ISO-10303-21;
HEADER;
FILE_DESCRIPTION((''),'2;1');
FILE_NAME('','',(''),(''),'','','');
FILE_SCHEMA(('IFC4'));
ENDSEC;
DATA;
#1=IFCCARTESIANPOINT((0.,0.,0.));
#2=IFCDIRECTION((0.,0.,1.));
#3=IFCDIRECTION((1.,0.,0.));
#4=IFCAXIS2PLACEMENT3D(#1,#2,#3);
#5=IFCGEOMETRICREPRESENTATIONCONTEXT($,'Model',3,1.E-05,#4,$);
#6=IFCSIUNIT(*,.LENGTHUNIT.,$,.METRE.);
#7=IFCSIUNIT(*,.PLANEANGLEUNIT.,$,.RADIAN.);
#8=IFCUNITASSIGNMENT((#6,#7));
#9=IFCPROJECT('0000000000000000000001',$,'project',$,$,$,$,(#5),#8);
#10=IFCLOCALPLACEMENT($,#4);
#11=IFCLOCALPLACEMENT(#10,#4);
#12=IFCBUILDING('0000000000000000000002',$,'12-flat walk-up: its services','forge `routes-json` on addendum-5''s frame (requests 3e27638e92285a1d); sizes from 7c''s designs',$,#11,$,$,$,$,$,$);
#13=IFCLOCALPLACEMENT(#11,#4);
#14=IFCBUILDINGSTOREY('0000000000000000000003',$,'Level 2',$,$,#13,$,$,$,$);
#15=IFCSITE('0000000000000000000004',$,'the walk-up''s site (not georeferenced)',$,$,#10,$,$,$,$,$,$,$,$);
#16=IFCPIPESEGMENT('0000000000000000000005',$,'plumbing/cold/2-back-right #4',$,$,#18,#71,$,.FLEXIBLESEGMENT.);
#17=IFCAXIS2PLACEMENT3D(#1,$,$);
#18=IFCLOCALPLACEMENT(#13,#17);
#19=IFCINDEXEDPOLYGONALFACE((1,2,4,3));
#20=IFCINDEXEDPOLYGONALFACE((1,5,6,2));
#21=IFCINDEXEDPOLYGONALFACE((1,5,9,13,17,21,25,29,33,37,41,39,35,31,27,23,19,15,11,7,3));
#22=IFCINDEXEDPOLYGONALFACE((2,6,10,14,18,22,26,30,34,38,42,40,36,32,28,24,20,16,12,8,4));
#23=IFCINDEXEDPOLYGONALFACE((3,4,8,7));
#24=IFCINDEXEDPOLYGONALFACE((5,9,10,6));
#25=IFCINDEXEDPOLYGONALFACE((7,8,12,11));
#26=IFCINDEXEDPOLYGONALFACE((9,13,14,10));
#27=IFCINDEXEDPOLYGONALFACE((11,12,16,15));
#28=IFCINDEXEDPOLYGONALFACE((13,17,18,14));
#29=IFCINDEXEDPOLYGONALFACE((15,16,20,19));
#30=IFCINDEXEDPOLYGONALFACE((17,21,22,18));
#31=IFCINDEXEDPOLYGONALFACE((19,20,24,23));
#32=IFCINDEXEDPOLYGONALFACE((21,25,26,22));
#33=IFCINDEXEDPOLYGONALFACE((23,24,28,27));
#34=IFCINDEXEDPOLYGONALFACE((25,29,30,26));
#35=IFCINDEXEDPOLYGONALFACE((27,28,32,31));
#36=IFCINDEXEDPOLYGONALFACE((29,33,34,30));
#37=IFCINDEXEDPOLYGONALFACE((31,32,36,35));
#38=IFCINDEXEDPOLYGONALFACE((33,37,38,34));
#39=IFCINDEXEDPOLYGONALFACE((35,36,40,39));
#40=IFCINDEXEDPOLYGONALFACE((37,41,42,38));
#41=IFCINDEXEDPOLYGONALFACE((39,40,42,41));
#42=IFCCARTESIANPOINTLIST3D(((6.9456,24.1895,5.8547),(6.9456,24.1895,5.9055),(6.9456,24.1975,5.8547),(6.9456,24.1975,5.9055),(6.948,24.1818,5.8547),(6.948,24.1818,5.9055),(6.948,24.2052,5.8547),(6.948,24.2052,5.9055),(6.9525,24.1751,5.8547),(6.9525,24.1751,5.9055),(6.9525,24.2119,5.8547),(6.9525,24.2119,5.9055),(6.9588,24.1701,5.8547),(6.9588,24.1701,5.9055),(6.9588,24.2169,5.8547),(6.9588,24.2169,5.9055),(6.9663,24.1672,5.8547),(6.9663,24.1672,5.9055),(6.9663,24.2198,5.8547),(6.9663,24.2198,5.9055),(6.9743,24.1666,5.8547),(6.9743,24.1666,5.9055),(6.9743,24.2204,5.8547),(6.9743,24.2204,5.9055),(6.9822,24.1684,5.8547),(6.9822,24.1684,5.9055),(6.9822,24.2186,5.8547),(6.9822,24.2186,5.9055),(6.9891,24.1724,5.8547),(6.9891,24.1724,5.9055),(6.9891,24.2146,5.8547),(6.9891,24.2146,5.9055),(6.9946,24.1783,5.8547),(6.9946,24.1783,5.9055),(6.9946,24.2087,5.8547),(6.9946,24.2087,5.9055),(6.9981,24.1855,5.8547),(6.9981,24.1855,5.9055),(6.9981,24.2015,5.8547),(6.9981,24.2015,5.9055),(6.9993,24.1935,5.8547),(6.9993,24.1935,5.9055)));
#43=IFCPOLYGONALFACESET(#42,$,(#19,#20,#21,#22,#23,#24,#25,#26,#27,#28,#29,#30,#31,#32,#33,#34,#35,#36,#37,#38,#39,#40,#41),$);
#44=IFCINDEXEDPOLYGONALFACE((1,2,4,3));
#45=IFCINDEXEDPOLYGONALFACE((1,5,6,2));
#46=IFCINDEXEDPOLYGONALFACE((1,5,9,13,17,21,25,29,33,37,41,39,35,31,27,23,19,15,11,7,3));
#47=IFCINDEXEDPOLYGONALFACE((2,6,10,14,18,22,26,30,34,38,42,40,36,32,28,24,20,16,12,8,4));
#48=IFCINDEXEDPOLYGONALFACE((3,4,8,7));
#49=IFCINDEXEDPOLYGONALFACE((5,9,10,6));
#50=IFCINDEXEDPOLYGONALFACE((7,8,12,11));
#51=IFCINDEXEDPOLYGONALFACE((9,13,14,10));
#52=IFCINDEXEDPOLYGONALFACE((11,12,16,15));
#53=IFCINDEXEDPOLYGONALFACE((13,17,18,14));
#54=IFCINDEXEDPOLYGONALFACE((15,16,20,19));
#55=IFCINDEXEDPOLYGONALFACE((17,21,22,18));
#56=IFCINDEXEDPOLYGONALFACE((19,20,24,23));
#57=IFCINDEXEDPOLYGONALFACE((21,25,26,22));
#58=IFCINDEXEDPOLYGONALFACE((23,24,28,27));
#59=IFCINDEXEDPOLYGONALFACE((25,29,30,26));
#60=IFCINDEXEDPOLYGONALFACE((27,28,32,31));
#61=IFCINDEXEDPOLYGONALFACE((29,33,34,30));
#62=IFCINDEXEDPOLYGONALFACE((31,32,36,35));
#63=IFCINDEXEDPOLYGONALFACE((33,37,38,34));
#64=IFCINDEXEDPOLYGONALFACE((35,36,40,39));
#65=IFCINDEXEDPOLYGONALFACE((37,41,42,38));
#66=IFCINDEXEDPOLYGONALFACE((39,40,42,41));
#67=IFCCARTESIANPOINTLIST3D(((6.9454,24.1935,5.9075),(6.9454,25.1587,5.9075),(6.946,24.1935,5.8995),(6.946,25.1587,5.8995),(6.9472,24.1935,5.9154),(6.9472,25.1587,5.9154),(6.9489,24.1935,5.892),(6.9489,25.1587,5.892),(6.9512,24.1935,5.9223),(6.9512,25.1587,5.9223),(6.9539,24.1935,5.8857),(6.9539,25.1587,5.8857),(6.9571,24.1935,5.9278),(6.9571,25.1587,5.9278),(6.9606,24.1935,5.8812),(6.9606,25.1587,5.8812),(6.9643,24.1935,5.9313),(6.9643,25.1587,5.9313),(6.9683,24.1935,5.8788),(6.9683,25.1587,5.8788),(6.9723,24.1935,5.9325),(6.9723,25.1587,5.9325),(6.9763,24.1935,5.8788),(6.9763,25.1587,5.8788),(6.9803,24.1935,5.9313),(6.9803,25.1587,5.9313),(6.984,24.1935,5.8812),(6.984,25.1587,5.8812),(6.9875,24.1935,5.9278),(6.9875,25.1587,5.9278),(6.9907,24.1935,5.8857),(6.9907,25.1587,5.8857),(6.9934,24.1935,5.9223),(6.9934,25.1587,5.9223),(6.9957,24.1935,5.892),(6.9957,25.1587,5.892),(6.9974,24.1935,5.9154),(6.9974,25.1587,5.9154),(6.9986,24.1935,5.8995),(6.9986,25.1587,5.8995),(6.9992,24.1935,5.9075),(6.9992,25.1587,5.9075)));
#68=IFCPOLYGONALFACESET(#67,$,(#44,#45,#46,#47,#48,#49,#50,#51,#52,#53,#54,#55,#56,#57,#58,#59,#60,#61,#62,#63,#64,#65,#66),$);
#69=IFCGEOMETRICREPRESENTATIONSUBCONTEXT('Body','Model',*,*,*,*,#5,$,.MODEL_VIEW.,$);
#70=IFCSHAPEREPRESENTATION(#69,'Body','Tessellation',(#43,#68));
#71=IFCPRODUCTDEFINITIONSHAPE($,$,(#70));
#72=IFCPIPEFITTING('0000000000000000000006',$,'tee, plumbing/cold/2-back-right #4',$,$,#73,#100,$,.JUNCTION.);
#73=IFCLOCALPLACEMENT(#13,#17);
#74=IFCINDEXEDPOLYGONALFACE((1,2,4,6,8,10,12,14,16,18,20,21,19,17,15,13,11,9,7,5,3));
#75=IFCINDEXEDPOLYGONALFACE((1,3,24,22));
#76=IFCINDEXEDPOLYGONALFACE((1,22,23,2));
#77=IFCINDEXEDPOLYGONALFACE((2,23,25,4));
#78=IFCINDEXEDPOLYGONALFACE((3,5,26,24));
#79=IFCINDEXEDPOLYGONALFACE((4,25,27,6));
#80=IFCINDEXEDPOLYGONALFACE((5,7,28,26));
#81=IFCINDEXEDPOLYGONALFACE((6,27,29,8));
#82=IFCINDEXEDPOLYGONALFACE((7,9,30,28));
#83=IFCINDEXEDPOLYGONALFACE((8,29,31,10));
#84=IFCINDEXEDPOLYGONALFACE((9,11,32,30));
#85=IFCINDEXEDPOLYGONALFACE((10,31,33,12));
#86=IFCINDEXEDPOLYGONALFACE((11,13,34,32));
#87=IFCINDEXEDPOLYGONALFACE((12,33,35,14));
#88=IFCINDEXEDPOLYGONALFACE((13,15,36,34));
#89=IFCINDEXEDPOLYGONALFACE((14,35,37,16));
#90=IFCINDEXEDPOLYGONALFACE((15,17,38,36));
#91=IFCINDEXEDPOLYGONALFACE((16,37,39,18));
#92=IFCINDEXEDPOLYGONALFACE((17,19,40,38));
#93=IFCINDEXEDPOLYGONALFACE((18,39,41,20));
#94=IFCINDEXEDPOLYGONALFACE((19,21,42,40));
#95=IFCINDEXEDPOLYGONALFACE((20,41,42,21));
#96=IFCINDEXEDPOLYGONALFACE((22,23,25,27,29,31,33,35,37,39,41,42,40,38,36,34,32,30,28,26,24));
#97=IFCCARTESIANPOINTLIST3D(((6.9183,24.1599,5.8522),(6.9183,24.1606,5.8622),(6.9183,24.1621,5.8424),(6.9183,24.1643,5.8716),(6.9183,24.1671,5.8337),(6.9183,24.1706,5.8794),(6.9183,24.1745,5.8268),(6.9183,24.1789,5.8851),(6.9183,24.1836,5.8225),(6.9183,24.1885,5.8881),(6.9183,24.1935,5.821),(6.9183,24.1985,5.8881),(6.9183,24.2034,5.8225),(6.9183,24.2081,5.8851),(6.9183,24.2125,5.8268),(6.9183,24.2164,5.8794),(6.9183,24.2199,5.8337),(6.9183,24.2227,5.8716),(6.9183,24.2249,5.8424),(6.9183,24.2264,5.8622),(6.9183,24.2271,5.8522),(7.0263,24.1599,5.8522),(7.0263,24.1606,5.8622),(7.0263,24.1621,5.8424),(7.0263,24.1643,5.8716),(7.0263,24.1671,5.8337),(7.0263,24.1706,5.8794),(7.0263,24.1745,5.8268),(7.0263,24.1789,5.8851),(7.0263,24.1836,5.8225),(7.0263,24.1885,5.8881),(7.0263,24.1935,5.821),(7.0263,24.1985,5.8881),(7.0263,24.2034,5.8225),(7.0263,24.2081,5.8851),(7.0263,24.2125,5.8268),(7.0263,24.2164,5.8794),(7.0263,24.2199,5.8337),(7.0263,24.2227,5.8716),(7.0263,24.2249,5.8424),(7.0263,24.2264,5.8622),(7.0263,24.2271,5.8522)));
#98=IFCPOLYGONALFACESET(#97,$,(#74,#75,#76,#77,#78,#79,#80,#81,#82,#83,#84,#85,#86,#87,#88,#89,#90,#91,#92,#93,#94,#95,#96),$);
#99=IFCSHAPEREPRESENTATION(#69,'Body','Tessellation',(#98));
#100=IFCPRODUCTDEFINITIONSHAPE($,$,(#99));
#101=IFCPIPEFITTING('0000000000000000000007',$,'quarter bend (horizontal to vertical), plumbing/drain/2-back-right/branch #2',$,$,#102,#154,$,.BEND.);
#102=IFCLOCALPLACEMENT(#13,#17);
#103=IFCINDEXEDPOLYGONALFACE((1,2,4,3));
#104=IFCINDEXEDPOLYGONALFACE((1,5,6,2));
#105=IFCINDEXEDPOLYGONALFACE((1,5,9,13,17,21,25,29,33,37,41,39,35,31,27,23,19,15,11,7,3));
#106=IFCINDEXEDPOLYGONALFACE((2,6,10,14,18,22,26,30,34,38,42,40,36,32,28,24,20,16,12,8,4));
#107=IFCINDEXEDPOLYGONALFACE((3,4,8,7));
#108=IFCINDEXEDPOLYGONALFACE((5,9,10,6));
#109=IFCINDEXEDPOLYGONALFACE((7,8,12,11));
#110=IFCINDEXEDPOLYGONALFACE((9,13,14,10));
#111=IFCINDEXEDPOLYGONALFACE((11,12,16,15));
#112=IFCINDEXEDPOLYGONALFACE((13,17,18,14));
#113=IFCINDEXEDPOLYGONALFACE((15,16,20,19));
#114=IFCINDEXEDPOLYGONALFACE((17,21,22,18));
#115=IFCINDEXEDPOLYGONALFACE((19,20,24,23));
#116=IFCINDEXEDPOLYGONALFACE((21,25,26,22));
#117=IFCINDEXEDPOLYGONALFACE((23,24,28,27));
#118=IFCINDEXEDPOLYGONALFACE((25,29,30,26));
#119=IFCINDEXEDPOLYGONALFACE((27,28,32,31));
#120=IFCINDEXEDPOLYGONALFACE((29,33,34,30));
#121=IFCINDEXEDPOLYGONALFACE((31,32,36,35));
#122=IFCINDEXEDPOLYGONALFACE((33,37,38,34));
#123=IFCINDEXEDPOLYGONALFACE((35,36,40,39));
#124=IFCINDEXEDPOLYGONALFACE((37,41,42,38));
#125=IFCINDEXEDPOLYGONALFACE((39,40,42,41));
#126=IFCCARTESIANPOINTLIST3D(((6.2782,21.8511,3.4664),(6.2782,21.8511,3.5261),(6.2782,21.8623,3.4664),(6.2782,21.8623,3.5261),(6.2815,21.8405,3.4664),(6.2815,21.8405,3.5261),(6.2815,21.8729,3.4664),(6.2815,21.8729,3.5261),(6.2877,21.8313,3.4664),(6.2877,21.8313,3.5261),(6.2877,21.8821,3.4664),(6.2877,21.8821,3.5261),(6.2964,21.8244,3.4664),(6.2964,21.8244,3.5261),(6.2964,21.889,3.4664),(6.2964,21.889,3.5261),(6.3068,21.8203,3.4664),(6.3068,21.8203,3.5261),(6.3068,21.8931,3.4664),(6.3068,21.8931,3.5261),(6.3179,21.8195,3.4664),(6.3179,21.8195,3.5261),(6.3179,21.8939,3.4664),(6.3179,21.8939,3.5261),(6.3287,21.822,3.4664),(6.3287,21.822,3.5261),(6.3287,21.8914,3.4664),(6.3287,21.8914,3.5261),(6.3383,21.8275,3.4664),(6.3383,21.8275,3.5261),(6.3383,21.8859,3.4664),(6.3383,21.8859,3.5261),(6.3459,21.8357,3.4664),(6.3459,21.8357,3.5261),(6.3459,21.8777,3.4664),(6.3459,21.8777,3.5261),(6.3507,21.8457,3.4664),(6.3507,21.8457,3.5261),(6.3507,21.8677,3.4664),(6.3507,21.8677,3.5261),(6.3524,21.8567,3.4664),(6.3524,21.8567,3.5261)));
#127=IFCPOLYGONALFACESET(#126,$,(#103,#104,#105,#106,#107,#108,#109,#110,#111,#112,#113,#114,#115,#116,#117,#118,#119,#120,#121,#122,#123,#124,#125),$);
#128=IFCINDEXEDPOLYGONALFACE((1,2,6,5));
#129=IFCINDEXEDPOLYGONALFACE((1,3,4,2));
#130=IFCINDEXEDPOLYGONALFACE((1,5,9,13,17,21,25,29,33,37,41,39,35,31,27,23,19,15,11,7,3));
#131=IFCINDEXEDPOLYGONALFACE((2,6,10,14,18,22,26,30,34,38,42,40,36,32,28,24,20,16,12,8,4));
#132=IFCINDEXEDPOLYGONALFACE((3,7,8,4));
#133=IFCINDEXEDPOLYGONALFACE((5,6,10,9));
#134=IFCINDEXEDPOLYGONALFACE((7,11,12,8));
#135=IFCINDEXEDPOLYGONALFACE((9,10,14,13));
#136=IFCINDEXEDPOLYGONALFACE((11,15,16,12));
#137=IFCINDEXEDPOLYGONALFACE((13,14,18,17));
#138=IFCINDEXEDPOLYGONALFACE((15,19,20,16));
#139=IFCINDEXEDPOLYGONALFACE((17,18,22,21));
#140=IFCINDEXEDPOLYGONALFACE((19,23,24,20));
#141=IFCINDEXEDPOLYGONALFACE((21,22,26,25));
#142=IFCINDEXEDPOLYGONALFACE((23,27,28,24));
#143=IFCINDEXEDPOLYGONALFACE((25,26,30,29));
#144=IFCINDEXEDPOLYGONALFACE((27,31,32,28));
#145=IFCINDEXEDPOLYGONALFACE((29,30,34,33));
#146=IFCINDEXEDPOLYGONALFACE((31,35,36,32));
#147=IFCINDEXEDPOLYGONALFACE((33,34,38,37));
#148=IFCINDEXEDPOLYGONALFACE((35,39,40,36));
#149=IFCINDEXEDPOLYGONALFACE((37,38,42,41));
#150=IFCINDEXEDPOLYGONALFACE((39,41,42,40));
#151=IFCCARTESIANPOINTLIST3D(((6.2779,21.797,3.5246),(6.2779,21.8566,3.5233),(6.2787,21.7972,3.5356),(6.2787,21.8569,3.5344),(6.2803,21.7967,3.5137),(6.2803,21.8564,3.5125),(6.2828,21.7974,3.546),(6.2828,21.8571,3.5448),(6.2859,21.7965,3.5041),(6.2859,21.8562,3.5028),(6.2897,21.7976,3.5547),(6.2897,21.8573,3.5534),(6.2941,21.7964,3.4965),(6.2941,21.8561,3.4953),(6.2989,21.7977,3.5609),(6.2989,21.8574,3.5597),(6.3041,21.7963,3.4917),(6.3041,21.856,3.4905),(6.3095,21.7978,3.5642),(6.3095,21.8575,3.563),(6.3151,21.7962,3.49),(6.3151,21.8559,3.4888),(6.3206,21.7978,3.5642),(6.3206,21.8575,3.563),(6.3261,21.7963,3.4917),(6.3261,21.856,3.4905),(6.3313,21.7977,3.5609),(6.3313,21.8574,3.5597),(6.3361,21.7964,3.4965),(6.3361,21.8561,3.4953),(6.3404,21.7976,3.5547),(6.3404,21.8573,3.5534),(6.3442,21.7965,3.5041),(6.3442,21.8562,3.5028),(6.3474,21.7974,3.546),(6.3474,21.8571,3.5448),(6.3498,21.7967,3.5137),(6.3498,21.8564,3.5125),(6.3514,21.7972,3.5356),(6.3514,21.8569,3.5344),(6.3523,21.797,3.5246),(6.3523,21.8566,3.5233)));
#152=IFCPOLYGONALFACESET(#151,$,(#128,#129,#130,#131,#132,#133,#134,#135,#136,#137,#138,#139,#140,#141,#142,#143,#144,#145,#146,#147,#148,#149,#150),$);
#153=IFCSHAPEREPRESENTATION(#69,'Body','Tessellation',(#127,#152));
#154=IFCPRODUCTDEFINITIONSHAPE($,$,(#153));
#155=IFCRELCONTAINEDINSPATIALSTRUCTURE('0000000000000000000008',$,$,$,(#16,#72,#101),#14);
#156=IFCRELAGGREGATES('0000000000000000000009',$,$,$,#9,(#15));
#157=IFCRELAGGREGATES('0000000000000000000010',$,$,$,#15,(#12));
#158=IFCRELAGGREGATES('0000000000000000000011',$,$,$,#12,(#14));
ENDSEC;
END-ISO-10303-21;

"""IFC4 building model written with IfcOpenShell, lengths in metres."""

from ifc_helpers import new_model, entity, si_unit, frame, origin_with_axes, place, context, subcontext, project, spatial, element, save


model = new_model("IFC4")

# Units and contexts
model_context = context("Model", 3, precision=1e-05, world=origin_with_axes())
body_context = subcontext(model_context, "Body", "Model", "MODEL_VIEW")
ifc_project = project(units=[si_unit("LENGTHUNIT", "METRE"), si_unit("PLANEANGLEUNIT", "RADIAN")], contexts=[model_context])

# Site, building, storey
site_placement = place(None, origin_with_axes())
site = spatial("IfcSite", under=ifc_project, at=site_placement, Name="the walk-up's site (not georeferenced)")
building_placement = place(site_placement, origin_with_axes())
building = spatial("IfcBuilding", under=site, at=building_placement, Name="12-flat walk-up: its services", Description="forge `routes-json` on addendum-5's frame (requests 3e27638e92285a1d); sizes from 7c's designs")
storey_placement = place(building_placement, origin_with_axes())
storey = spatial("IfcBuildingStorey", under=building, at=storey_placement, Name="Level 2")

# Pipe segment
pipe_segment_1_placement = place(storey_placement, frame((6.9723, 24.1935, 5.8547), z_axis=(0.0, 0.0, 1.0), x_axis=(1.0, 0.0, 0.0)))
element("IfcPipeSegment", 1, at=pipe_segment_1_placement, inside=storey, Name="plumbing/cold/2-back-right #4", PredefinedType="FLEXIBLESEGMENT", context=body_context, shape_type="AdvancedSweptSolid", body=[
    entity("IfcSweptDiskSolid", entity("IfcPolyline", [entity("IfcCartesianPoint", [0.0, 0.0, 0.0]), entity("IfcCartesianPoint", [0.0, 0.0, 0.0508])]), 0.027),
    entity("IfcSweptDiskSolid", entity("IfcPolyline", [entity("IfcCartesianPoint", [0.0, 0.0, 0.0508]), entity("IfcCartesianPoint", [0.0, 0.9652, 0.0508])]), 0.027),
])

# Pipe fittings
pipe_fitting_1_placement = place(storey_placement, frame((7.0263, 24.1935, 5.8547), z_axis=(0.0, 0.0, 1.0), x_axis=(1.0, 0.0, 0.0)))
element("IfcPipeFitting", 2, at=pipe_fitting_1_placement, inside=storey, Name="tee, plumbing/cold/2-back-right #4", PredefinedType="JUNCTION", context=body_context, shape_type="AdvancedSweptSolid", body=[
    entity("IfcSweptDiskSolid", entity("IfcPolyline", [entity("IfcCartesianPoint", [0.0, 0.0, 0.0]), entity("IfcCartesianPoint", [-0.108, 0.0, 0.0])]), 0.0337),
])
pipe_fitting_2_placement = place(storey_placement, frame((6.3151, 21.8567, 3.4664), z_axis=(0.0, 0.0, 1.0), x_axis=(1.0, 0.0, 0.0)))
element("IfcPipeFitting", 3, at=pipe_fitting_2_placement, inside=storey, Name="quarter bend (horizontal to vertical), plumbing/drain/2-back-right/branch #2", PredefinedType="BEND", context=body_context, shape_type="AdvancedSweptSolid", body=[
    entity("IfcSweptDiskSolid", entity("IfcPolyline", [entity("IfcCartesianPoint", [0.0, 0.0, 0.0]), entity("IfcCartesianPoint", [0.0, 0.0, 0.0597])]), 0.0373),
    entity("IfcSweptDiskSolid", entity("IfcPolyline", [entity("IfcCartesianPoint", [0.0, 0.0, 0.0597]), entity("IfcCartesianPoint", [0.0, -0.0597, 0.0609])]), 0.0373),
])

save(model, "model.ifc")
